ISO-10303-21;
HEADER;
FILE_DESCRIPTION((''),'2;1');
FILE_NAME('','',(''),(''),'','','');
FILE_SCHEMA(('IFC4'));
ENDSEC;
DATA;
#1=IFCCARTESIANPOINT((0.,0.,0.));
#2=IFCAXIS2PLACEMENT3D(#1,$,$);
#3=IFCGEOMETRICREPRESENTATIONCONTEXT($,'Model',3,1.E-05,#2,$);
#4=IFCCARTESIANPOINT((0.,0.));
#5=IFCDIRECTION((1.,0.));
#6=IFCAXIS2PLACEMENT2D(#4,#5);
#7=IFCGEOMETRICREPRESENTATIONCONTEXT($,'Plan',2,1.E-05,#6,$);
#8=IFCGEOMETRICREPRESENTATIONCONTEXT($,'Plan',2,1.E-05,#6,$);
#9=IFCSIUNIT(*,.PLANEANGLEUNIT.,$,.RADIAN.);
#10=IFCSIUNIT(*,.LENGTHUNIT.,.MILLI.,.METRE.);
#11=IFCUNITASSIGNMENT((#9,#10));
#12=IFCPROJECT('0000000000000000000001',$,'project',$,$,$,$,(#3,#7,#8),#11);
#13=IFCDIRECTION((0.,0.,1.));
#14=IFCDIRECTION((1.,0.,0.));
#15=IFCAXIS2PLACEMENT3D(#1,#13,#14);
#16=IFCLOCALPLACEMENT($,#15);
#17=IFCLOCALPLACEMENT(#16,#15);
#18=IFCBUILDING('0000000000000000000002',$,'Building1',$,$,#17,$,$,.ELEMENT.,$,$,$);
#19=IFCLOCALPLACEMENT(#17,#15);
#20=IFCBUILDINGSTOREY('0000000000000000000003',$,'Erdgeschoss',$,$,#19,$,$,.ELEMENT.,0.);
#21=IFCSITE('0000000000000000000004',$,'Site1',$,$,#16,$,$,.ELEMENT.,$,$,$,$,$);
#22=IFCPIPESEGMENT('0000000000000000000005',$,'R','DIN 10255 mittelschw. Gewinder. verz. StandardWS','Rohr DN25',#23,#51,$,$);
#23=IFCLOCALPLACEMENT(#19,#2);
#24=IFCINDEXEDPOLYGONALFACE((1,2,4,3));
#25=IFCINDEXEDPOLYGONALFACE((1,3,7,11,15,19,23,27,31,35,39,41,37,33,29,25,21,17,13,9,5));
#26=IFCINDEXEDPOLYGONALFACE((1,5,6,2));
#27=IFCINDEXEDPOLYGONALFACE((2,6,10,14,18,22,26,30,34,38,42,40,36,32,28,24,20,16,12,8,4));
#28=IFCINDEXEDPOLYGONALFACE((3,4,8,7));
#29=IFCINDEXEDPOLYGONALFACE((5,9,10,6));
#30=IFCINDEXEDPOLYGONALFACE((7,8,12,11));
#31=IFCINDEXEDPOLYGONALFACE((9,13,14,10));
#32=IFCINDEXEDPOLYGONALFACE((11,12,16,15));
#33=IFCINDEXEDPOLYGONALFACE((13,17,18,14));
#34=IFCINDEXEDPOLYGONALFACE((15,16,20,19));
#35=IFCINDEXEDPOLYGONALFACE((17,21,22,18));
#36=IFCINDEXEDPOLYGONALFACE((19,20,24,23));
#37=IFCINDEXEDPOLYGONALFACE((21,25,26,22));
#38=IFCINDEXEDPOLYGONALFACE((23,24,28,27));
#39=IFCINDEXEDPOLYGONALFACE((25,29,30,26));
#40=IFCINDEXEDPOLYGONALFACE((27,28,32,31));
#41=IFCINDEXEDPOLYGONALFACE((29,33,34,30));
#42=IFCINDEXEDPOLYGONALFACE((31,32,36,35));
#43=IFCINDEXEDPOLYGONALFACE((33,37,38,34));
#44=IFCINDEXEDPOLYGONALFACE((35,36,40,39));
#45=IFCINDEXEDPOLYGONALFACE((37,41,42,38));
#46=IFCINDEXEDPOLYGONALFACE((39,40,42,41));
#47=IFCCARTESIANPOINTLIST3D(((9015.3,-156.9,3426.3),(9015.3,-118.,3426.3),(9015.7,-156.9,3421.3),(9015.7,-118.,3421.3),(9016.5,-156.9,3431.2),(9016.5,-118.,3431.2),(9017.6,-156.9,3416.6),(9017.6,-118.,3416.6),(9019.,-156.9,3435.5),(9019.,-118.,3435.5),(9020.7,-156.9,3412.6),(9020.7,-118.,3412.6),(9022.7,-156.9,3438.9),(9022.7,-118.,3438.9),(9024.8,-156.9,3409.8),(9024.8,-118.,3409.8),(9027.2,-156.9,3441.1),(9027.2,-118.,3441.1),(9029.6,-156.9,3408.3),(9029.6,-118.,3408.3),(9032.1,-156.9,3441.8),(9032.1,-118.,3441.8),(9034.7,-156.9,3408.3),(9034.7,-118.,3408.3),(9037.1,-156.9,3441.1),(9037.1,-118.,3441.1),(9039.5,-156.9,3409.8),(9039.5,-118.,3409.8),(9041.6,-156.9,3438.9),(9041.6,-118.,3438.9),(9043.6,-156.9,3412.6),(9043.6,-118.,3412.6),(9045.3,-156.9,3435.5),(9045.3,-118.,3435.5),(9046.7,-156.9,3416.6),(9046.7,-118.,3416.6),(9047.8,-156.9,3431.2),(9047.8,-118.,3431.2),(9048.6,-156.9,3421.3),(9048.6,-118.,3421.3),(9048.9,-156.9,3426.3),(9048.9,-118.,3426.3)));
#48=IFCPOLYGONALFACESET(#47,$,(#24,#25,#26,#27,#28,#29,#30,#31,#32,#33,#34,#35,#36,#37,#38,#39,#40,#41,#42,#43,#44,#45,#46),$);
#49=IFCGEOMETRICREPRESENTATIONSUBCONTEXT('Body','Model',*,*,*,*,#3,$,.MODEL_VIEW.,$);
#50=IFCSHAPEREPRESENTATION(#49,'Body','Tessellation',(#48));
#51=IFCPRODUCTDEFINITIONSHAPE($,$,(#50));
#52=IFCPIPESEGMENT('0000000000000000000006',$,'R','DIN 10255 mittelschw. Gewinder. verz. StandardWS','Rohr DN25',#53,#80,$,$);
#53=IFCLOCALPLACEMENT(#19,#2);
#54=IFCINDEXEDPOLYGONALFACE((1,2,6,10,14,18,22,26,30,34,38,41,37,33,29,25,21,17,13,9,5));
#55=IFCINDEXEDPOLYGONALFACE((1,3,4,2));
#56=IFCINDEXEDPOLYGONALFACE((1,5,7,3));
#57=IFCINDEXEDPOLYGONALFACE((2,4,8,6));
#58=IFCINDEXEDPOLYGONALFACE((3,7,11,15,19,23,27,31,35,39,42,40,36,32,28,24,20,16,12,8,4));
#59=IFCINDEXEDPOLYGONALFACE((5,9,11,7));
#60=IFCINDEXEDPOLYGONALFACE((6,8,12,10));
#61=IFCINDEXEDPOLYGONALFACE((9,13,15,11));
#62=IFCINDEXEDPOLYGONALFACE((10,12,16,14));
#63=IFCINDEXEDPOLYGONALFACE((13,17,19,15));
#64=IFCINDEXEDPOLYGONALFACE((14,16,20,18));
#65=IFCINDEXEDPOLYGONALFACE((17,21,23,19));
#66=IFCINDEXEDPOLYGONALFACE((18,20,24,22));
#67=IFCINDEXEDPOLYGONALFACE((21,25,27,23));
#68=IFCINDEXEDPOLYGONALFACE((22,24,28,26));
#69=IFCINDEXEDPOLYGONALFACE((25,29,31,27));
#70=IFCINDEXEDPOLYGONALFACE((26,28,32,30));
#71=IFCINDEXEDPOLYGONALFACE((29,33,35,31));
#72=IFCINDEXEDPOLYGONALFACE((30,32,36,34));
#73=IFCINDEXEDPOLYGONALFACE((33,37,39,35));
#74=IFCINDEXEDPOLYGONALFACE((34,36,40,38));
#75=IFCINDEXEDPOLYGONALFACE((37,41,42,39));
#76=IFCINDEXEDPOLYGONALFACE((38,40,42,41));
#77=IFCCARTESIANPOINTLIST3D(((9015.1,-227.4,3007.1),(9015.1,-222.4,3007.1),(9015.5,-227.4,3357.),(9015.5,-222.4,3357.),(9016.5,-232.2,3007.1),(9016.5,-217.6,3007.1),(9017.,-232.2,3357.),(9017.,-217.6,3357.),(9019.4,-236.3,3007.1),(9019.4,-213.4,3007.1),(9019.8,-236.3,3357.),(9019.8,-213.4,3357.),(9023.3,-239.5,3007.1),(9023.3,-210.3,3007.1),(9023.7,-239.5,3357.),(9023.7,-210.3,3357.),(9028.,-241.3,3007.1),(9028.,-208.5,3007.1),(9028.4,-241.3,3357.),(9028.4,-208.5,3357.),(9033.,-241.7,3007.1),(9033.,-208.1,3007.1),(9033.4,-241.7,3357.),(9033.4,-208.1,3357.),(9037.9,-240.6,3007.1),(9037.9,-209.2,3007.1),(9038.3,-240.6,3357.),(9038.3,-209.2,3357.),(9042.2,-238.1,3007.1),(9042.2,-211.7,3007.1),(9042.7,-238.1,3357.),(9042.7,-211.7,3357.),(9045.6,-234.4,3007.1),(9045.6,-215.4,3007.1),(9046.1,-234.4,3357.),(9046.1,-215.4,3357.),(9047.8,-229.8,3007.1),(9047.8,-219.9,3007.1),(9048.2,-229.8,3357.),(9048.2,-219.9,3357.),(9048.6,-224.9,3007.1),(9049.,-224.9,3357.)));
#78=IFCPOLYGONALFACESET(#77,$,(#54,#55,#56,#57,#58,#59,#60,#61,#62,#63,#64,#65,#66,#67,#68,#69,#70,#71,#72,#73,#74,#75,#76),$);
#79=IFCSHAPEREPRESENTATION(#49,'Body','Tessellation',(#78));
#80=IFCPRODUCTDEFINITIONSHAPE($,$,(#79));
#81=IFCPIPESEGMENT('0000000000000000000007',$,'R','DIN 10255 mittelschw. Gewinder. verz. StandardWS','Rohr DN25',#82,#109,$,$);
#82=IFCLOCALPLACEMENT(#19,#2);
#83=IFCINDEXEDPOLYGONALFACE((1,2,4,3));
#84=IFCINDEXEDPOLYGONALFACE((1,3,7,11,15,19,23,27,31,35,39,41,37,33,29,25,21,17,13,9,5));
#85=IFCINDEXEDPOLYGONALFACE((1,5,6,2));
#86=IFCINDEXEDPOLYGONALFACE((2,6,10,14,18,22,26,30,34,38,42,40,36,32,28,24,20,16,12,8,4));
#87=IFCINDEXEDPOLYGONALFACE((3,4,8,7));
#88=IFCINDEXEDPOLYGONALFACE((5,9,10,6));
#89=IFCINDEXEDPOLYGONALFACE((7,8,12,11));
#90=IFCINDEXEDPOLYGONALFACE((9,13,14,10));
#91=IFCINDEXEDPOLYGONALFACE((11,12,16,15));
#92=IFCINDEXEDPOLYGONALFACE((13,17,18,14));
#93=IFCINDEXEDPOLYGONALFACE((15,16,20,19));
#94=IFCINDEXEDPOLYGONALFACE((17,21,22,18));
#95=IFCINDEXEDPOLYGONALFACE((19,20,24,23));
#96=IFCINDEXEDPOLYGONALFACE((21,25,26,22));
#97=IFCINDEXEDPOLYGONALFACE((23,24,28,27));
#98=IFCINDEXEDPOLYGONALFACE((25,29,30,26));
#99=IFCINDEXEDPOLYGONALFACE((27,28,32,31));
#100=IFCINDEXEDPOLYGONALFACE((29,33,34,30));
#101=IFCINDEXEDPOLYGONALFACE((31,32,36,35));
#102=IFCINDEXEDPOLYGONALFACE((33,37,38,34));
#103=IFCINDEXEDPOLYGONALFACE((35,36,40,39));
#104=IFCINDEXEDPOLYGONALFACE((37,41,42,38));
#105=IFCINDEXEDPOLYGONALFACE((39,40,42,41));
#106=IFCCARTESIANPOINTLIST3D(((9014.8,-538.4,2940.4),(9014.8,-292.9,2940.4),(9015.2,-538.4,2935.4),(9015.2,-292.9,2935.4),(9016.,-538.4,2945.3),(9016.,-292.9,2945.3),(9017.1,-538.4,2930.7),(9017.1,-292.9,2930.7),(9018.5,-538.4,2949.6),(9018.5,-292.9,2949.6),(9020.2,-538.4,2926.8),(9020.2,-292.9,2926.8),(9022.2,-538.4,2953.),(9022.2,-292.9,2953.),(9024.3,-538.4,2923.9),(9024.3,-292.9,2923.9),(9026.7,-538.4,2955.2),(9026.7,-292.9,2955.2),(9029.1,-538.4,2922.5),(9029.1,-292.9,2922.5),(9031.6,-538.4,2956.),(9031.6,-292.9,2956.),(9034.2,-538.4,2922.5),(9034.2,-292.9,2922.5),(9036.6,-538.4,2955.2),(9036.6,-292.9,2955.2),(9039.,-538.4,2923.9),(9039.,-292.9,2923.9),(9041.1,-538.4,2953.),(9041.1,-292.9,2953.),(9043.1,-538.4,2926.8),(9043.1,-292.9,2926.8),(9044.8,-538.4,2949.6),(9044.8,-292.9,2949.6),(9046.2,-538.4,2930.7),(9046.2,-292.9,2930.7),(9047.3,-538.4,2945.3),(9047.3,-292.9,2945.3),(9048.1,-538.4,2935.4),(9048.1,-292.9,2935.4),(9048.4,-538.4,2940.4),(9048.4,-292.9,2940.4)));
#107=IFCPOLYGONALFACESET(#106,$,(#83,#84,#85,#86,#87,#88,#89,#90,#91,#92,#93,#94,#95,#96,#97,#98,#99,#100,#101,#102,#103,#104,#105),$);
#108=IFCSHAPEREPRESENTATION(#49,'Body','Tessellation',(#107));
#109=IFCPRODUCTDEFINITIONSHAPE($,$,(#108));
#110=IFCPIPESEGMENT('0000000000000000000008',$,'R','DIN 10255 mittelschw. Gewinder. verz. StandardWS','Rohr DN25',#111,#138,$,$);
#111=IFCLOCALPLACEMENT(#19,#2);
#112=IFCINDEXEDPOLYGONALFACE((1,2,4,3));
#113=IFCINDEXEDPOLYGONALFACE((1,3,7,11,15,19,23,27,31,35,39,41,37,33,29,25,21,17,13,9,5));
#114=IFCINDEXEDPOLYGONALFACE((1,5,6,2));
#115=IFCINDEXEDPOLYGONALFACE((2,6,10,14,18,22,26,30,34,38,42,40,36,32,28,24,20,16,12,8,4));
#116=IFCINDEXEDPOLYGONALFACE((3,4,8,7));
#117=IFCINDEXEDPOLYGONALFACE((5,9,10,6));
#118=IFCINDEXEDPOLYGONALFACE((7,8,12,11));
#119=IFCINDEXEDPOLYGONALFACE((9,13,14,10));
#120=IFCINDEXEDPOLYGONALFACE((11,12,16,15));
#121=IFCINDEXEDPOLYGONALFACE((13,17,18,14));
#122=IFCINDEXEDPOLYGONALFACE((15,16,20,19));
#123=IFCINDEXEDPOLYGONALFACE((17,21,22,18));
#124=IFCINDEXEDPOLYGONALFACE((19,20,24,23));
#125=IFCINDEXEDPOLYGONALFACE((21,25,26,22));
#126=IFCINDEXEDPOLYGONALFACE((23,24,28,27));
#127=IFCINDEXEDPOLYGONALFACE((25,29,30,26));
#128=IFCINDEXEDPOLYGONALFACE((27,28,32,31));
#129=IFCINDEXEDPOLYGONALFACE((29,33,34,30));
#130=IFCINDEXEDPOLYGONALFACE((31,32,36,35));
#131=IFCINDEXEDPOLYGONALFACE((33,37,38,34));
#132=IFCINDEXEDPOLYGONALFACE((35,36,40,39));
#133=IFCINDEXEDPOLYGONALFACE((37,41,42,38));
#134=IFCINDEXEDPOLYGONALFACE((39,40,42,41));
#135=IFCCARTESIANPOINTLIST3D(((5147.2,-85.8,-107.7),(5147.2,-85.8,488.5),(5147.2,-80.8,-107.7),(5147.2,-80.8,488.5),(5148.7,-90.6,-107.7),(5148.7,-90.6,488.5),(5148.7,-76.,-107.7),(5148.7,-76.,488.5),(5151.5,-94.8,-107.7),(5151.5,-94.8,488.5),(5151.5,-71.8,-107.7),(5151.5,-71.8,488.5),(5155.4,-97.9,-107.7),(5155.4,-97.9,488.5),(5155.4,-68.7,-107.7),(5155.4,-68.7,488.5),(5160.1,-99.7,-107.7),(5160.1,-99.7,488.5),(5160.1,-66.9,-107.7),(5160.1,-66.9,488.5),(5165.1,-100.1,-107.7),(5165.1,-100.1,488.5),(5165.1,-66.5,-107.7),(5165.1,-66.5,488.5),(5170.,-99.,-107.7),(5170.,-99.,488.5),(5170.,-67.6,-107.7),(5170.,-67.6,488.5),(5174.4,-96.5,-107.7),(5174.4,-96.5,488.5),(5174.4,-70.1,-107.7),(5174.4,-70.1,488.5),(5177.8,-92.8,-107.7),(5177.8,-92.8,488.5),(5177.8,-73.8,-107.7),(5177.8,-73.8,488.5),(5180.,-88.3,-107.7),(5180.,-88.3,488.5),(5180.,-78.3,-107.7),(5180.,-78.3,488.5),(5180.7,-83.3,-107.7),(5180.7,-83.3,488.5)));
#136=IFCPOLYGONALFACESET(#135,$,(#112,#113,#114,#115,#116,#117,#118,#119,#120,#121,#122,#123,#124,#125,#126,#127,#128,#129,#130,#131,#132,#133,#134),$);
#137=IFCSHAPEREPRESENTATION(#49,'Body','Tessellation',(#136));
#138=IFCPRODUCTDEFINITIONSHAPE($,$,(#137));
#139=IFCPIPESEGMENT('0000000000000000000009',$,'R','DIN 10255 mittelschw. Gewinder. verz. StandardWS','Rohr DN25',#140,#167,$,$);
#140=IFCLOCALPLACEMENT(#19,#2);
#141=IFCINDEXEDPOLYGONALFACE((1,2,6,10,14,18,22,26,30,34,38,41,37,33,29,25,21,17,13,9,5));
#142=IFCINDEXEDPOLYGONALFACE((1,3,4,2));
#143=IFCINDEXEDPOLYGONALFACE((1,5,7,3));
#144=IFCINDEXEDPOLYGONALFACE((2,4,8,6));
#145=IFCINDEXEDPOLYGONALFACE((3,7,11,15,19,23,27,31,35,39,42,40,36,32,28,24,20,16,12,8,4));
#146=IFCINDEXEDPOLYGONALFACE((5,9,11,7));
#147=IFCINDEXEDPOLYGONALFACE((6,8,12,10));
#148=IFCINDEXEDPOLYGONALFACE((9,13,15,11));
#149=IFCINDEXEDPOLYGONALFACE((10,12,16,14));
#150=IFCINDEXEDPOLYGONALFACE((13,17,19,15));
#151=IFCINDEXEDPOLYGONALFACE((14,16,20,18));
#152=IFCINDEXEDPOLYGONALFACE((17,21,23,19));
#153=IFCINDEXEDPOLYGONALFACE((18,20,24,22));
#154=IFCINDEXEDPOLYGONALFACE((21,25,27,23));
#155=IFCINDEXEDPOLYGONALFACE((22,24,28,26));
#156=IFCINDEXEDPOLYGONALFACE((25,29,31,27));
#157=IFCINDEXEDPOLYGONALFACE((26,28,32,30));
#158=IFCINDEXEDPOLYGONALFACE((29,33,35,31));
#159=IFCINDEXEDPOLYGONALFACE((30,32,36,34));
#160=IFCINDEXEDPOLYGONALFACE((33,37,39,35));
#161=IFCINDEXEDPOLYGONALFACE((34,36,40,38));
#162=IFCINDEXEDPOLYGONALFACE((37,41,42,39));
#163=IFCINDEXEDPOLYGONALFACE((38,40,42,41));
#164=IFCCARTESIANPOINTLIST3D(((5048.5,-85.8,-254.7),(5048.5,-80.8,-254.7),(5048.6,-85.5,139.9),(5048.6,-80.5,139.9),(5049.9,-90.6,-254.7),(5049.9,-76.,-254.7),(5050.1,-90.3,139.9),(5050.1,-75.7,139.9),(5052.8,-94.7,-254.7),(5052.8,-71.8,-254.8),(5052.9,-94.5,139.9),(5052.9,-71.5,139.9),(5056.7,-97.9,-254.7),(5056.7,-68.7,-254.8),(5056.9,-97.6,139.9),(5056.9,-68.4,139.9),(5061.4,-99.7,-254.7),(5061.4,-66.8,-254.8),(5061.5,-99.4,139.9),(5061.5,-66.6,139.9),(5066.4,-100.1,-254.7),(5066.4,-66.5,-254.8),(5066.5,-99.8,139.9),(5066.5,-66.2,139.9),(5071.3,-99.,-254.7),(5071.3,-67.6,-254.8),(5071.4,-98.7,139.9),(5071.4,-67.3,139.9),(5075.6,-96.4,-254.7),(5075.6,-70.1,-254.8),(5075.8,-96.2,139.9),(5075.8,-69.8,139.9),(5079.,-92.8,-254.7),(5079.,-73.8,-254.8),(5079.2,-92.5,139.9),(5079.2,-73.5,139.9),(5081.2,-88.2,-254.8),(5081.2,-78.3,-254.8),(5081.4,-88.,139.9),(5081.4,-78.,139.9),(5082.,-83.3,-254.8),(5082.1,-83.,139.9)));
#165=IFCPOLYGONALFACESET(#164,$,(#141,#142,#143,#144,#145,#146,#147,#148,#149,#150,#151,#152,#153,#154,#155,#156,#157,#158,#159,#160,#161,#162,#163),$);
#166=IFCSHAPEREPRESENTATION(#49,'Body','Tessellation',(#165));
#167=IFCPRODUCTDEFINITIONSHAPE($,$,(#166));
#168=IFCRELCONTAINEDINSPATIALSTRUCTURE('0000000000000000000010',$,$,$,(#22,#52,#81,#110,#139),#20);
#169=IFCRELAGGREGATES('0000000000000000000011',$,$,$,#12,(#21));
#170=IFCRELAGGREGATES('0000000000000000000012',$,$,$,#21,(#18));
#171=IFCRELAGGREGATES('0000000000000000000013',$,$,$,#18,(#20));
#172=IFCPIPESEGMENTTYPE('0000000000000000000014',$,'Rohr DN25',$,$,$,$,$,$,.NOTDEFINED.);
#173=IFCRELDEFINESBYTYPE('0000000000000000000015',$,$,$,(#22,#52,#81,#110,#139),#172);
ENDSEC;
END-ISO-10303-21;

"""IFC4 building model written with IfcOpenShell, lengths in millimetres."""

from ifc_helpers import new_model, si_unit, frame, origin, origin_with_axes, origin_2d_with_axis, place, context, subcontext, project, spatial, circle, extrude, type_object, element, save


model = new_model("IFC4")

# Units and contexts
model_context = context("Model", 3, precision=1e-05, world=origin())
plan_context_1 = context("Plan", 2, precision=1e-05, world=origin_2d_with_axis())
plan_context_2 = context("Plan", 2, precision=1e-05, world=origin_2d_with_axis())
body_context = subcontext(model_context, "Body", "Model", "MODEL_VIEW")
ifc_project = project(units=[si_unit("PLANEANGLEUNIT", "RADIAN"), si_unit("LENGTHUNIT", "METRE", prefix="MILLI")], contexts=[model_context, plan_context_1, plan_context_2])

# Site, building, storey
site_placement = place(None, origin_with_axes())
site = spatial("IfcSite", under=ifc_project, at=site_placement, Name="Site1", CompositionType="ELEMENT")
building_placement = place(site_placement, origin_with_axes())
building = spatial("IfcBuilding", under=site, at=building_placement, Name="Building1", CompositionType="ELEMENT")
storey_placement = place(building_placement, origin_with_axes())
storey = spatial("IfcBuildingStorey", under=building, at=storey_placement, Name="Erdgeschoss", CompositionType="ELEMENT", Elevation=0.0)

# Pipe segments
pipe_segment_type_1 = type_object("IfcPipeSegmentType", Name="Rohr DN25", PredefinedType="NOTDEFINED")
pipe_segment_1_placement = place(storey_placement, frame((9032.3, -137.4, 3425.0), z_axis=(0.0, 0.0, 1.0), x_axis=(1.0, 0.0, 0.0)))
element("IfcPipeSegment", 1, at=pipe_segment_1_placement, inside=storey, type_object=pipe_segment_type_1, Name="R", Description="DIN 10255 mittelschw. Gewinder. verz. StandardWS", ObjectType="Rohr DN25", context=body_context, shape_type="SolidModel", body=[
    extrude(circle(Radius=16.9, at=origin_2d_with_axis()), frame((-0.1, 19.4, 0.0), z_axis=(0.0, -1.0, 0.0), x_axis=(0.0, 0.0, 1.0)), (0.0, 0.0, 1.0), 38.9),
])
pipe_segment_2_placement = place(storey_placement, frame((9031.9, -225.0, 3182.1), z_axis=(0.0, 0.0, 1.0), x_axis=(1.0, 0.0, 0.0)))
element("IfcPipeSegment", 2, at=pipe_segment_2_placement, inside=storey, type_object=pipe_segment_type_1, Name="R", Description="DIN 10255 mittelschw. Gewinder. verz. StandardWS", ObjectType="Rohr DN25", context=body_context, shape_type="SolidModel", body=[
    extrude(circle(Radius=16.9, at=origin_2d_with_axis()), frame((0.2, 0.2, 174.9), z_axis=(-0.001207, 0.0, -0.999999), x_axis=(1.0, 0.0, 0.0)), (0.0, 0.0, 1.0), 349.9),
])
pipe_segment_3_placement = place(storey_placement, frame((9031.5, -415.6, 2939.1), z_axis=(0.0, 0.0, 1.0), x_axis=(1.0, 0.0, 0.0)))
element("IfcPipeSegment", 3, at=pipe_segment_3_placement, inside=storey, type_object=pipe_segment_type_1, Name="R", Description="DIN 10255 mittelschw. Gewinder. verz. StandardWS", ObjectType="Rohr DN25", context=body_context, shape_type="SolidModel", body=[
    extrude(circle(Radius=16.9, at=origin_2d_with_axis()), frame((0.1, -122.8, 0.0), z_axis=(0.0, 1.0, 0.0), x_axis=(0.0, 0.0, 1.0)), (0.0, 0.0, 1.0), 245.5),
])
pipe_segment_4_placement = place(storey_placement, frame((5163.9, -83.4, 190.4), z_axis=(0.0, 0.0, 1.0), x_axis=(1.0, 0.0, 0.0)))
element("IfcPipeSegment", 4, at=pipe_segment_4_placement, inside=storey, type_object=pipe_segment_type_1, Name="R", Description="DIN 10255 mittelschw. Gewinder. verz. StandardWS", ObjectType="Rohr DN25", context=body_context, shape_type="SolidModel", body=[
    extrude(circle(Radius=16.9, at=origin_2d_with_axis()), frame((0.0, 0.1, -298.1), z_axis=(0.0, 0.0, 1.0), x_axis=(1.0, 0.0, 0.0)), (0.0, 0.0, 1.0), 596.2),
])
pipe_segment_5_placement = place(storey_placement, frame((5065.2, -83.3, -57.4), z_axis=(0.0, 0.0, 1.0), x_axis=(1.0, 0.0, 0.0)))
element("IfcPipeSegment", 5, at=pipe_segment_5_placement, inside=storey, type_object=pipe_segment_type_1, Name="R", Description="DIN 10255 mittelschw. Gewinder. verz. StandardWS", ObjectType="Rohr DN25", context=body_context, shape_type="SolidModel", body=[
    extrude(circle(Radius=16.9, at=origin_2d_with_axis()), frame((-0.1, 0.0, -197.3), z_axis=(0.000425, 0.000703, 1.0), x_axis=(1.0, 0.0, 0.0)), (0.0, 0.0, 1.0), 394.7),
])

save(model, "model.ifc")
